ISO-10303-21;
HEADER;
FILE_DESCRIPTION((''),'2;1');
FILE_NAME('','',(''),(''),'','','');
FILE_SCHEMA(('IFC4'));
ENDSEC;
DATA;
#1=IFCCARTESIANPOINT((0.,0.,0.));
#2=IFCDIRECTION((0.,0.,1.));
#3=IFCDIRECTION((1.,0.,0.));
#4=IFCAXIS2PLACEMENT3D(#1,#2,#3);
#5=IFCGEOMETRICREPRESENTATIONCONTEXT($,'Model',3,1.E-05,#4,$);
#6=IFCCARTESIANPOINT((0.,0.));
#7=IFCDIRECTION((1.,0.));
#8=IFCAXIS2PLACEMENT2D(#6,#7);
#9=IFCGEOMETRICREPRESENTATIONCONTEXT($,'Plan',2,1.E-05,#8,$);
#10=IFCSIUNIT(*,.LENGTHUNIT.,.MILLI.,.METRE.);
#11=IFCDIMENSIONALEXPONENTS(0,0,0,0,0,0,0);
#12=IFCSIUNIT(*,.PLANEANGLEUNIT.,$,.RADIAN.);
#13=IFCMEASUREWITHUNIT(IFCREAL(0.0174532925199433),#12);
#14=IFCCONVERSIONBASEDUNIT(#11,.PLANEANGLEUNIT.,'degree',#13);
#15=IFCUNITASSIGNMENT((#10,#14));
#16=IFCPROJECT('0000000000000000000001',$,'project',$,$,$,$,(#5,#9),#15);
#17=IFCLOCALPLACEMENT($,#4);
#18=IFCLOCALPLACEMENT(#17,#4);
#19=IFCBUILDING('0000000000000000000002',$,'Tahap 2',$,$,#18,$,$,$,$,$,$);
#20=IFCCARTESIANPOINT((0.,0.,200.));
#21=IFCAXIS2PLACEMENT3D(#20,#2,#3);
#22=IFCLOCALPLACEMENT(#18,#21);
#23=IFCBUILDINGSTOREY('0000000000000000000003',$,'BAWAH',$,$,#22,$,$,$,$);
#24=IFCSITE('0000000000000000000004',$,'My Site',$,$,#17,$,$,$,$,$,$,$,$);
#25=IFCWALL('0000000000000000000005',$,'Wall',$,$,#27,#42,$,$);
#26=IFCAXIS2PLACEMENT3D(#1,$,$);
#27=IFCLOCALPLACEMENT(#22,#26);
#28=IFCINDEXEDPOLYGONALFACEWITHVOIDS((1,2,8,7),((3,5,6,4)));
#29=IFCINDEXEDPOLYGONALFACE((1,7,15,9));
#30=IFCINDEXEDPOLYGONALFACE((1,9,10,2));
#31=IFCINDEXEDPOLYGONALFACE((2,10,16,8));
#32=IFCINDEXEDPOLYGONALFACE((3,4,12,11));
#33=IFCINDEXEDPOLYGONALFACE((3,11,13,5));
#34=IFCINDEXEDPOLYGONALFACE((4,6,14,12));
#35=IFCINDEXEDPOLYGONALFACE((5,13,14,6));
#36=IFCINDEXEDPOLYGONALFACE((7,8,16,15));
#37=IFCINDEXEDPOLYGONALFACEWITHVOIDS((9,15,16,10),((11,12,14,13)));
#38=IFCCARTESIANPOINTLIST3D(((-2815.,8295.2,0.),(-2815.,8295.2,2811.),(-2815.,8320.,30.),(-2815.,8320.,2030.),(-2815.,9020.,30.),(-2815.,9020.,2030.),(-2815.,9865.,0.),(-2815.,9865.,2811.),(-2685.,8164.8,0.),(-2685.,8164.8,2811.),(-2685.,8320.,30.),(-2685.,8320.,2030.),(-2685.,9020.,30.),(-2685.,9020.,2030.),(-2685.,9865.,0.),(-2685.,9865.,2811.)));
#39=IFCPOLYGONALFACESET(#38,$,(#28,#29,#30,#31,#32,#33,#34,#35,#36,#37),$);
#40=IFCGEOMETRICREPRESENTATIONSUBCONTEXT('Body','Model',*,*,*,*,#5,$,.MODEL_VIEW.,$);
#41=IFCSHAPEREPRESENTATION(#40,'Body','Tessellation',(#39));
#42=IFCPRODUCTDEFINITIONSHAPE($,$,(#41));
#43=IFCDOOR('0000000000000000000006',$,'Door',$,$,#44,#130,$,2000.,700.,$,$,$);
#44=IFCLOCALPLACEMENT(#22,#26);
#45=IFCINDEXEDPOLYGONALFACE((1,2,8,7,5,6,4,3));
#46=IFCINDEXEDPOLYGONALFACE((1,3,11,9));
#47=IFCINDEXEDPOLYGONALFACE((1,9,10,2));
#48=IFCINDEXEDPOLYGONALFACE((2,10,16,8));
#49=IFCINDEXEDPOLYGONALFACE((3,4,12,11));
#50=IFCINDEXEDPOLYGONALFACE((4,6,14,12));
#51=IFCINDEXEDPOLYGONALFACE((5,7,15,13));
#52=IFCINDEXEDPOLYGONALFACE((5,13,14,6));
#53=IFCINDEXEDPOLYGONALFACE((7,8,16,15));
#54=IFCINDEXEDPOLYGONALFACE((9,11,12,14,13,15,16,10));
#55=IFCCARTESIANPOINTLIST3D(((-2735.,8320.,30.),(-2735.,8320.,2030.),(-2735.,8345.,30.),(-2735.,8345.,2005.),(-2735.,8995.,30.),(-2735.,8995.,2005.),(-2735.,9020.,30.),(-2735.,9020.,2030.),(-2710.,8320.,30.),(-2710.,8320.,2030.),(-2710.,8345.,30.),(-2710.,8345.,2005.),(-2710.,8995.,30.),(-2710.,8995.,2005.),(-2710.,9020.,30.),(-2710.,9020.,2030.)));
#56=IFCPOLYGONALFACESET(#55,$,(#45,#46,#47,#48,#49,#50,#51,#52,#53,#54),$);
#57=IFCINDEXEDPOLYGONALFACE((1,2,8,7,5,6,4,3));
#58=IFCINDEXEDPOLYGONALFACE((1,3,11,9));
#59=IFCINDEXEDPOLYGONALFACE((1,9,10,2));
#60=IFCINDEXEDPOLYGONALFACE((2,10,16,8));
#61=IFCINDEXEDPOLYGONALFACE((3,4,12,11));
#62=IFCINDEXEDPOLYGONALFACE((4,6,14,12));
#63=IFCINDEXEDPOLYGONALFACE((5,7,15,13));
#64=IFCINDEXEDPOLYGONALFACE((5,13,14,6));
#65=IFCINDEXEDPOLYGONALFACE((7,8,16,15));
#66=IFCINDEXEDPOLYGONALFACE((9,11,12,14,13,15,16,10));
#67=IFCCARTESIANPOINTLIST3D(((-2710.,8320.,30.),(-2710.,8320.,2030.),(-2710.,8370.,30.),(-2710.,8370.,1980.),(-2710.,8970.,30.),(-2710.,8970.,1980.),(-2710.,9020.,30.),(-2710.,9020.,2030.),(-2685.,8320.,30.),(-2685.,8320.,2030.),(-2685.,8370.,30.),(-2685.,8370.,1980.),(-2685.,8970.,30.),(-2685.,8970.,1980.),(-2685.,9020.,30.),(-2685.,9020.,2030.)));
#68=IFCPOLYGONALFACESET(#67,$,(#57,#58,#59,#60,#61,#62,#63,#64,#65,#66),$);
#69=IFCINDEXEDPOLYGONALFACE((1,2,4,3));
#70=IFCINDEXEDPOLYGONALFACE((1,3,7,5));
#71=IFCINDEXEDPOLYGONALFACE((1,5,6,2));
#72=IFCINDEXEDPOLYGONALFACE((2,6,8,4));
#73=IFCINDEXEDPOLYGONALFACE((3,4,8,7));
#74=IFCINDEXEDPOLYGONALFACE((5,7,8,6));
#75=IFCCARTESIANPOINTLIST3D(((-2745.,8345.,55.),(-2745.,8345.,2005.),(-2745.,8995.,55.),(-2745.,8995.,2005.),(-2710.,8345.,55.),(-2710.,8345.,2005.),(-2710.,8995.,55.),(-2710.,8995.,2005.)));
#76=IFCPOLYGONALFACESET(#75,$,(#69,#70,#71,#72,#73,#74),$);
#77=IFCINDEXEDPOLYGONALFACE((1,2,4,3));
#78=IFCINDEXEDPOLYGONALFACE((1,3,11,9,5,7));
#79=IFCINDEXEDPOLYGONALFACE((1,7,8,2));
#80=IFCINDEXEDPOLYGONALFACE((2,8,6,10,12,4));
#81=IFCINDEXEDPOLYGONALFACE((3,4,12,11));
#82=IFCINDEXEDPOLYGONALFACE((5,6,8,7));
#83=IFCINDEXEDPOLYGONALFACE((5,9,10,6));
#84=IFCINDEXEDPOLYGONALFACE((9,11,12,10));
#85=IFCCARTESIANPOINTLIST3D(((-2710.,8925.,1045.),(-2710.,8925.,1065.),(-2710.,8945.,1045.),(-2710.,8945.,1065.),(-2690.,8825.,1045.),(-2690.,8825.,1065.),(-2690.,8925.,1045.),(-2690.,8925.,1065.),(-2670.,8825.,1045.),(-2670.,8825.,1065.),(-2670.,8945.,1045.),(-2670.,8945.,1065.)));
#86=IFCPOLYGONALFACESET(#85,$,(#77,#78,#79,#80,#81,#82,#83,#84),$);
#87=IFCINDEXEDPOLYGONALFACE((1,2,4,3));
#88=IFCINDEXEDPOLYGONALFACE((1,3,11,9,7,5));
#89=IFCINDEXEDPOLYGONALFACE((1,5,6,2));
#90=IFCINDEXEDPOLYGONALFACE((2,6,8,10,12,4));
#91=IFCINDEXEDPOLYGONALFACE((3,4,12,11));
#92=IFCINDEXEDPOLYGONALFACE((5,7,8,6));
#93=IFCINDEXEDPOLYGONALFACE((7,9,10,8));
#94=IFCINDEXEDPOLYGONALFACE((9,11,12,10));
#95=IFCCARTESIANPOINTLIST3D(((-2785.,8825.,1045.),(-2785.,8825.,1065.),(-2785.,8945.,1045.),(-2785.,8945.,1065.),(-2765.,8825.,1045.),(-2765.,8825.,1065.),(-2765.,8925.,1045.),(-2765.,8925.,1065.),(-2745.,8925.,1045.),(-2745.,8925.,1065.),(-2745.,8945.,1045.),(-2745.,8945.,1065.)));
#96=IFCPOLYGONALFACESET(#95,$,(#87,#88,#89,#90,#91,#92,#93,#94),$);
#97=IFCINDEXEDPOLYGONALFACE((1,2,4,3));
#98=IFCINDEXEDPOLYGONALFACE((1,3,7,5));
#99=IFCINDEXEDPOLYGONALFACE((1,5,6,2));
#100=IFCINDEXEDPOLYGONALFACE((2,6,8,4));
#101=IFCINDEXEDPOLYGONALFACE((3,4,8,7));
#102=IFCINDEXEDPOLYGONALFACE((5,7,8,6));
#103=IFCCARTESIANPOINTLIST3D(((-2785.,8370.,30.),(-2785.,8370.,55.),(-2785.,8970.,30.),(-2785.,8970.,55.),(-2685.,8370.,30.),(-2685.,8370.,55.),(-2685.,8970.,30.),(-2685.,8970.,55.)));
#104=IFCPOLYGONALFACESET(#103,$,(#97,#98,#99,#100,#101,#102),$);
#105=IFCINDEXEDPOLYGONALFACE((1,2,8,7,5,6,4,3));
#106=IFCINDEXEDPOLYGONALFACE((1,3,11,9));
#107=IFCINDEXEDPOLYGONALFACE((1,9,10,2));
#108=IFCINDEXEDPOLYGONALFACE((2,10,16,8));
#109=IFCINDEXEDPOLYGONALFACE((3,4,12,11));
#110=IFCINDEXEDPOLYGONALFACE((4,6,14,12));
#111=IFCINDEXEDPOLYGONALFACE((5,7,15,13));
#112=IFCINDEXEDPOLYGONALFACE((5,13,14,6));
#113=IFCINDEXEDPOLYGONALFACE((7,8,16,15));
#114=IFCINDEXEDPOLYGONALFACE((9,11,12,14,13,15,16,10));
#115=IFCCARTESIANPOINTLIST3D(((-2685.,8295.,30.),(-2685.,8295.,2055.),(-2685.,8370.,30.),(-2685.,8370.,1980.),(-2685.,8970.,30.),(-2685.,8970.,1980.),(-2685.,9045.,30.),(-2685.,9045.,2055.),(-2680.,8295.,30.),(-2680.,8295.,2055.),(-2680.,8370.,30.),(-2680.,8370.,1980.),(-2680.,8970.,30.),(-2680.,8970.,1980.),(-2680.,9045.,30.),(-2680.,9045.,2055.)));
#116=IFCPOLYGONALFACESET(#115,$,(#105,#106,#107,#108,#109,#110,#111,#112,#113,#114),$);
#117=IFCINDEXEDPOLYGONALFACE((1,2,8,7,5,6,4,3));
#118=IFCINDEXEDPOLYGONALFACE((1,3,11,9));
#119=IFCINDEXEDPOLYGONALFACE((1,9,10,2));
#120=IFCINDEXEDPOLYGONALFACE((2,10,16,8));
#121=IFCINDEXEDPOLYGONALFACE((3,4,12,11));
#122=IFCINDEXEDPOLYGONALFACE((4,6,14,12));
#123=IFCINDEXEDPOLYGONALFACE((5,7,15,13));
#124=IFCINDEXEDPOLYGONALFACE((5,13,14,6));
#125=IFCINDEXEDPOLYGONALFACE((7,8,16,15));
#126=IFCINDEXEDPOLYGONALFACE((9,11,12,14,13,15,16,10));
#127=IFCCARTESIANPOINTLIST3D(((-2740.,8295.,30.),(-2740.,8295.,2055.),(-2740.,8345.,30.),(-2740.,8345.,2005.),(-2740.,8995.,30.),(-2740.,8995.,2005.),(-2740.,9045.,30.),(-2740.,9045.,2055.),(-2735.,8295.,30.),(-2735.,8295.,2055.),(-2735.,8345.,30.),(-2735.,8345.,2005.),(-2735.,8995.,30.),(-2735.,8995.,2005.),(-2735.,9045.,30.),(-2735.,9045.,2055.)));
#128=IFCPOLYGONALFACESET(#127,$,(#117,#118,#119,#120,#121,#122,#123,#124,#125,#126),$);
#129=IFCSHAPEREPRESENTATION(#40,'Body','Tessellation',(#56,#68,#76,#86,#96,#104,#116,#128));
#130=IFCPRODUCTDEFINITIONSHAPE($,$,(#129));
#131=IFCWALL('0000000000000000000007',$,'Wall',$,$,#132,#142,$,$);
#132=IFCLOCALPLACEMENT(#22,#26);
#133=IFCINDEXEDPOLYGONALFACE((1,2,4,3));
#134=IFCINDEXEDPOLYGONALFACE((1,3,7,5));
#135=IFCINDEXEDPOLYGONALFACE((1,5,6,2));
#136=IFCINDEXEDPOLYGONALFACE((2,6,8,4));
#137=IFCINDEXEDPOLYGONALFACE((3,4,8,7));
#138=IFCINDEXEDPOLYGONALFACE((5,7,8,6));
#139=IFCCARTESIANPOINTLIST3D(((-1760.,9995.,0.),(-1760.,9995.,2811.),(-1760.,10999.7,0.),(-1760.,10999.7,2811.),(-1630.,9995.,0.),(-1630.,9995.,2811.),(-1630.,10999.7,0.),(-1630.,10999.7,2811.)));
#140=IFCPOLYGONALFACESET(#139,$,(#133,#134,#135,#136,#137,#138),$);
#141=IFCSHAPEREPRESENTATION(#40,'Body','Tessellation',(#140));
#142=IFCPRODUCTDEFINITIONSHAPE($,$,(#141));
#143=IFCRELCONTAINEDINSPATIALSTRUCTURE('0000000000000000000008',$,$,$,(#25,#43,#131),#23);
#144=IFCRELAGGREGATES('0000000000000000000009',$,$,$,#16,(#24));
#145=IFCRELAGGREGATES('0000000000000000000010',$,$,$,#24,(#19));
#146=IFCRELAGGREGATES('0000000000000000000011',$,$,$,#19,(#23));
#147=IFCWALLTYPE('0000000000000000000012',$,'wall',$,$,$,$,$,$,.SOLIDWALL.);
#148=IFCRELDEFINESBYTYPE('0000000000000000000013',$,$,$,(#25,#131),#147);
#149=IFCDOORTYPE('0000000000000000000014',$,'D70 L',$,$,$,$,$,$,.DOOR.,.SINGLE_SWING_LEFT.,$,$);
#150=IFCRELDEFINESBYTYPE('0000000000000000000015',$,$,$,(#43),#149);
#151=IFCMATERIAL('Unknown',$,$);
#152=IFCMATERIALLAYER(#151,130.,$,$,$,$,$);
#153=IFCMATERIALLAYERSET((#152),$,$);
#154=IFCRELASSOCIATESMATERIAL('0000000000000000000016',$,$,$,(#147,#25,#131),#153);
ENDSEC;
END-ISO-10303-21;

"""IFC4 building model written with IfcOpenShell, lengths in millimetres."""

from ifc_helpers import new_model, entity, si_unit, converted_unit, frame, origin_with_axes, origin_2d_with_axis, place, context, subcontext, project, spatial, line, indexed_curve, outline, extrude, shape, source, transform, mapped, material, layer, layer_set, layer_usage, type_object, type_shapes, element, fill, save


model = new_model("IFC4")

# Units and contexts
model_context = context("Model", 3, precision=1e-05, world=origin_with_axes())
plan_context = context("Plan", 2, precision=1e-05, world=origin_2d_with_axis())
body_context_1 = subcontext(model_context, "Body", "Model", "MODEL_VIEW")
body_context_2 = subcontext(plan_context, "Body", "Plan", "PLAN_VIEW")
ifc_project = project(units=[si_unit("LENGTHUNIT", "METRE", prefix="MILLI"), converted_unit("PLANEANGLEUNIT", "degree", entity("IfcReal", 0.0174532925199433), si_unit("PLANEANGLEUNIT", "RADIAN"), dimensions=[0, 0, 0, 0, 0, 0, 0])], contexts=[model_context, plan_context])

# Site, building, storey
site_placement = place(None, origin_with_axes())
site = spatial("IfcSite", under=ifc_project, at=site_placement, Name="My Site")
building_placement = place(site_placement, origin_with_axes())
building = spatial("IfcBuilding", under=site, at=building_placement, Name="Tahap 2")
storey_placement = place(building_placement, frame((0.0, 0.0, 200.0), z_axis=(0.0, 0.0, 1.0), x_axis=(1.0, 0.0, 0.0)))
storey = spatial("IfcBuildingStorey", under=building, at=storey_placement, Name="BAWAH")

# Wall, opening, door
ifc_material_1 = material(Name="Unknown")
ifc_layer_1 = layer(ifc_material_1, 130.0)
ifc_layer_set_1 = layer_set([ifc_layer_1])
ifc_layer_usage_1 = layer_usage(ifc_layer_set_1, "AXIS2", "POSITIVE", 0.0)
wall_type = type_object("IfcWallType", Name="wall", PredefinedType="SOLIDWALL", material=ifc_layer_set_1)
wall_1_placement = place(storey_placement, frame((-2685.0, 8164.8, 0.0), z_axis=(0.0, 0.0, 1.0), x_axis=(0.0, 1.0, 0.0)))
wall_1 = element("IfcWall", 1, at=wall_1_placement, inside=storey, type_object=wall_type, material=ifc_layer_usage_1, Name="Wall", context=body_context_1, shape_type="SweptSolid", body=[
    extrude(outline(indexed_curve([(0.0, 0.0), (130.3, 130.0), (1700.2, 130.0), (1700.2, 0.0)], segments=[line(1, 2, 3, 4, 1)])), origin_with_axes(), (0.0, 0.0, 1.0), 2811.0),
])
shared_shape_1 = source(origin_with_axes(), body_context_1, "Body", "SweptSolid", [
    extrude(outline(indexed_curve([(0.0, 0.0), (700.0, 0.0), (700.0, 2000.0), (0.0, 2000.0)], segments=[line(1, 2, 3, 4, 1)])), frame((0.0, -600.0, 0.0), z_axis=(0.0, -1.0, 0.0), x_axis=(1.0, 0.0, 0.0)), (0.0, 0.0, -1.0), 1200.0),
])
opening_placement = place(wall_1_placement, frame((155.2, 0.0, 30.0), z_axis=(0.0, 0.0, 1.0), x_axis=(1.0, 0.0, 0.0)))
opening = element("IfcOpeningElement", 2, at=opening_placement, cuts=wall_1, PredefinedType="OPENING", context=body_context_1, shape_type="MappedRepresentation", body=[
    mapped(shared_shape_1, transform((0.0, 0.0, 0.0), x_axis=(1.0, 0.0, 0.0), y_axis=(0.0, 1.0, 0.0), z_axis=(0.0, 0.0, 1.0), scale=1.0)),
])
door_type = type_object("IfcDoorType", Name="D70 L", OperationType="SINGLE_SWING_LEFT", PredefinedType="DOOR")
shared_shape_2 = source(origin_with_axes(), body_context_1, "Body", "SweptSolid", [
    extrude(outline(indexed_curve([(0.0, 0.0), (0.0, 2000.0), (700.0, 2000.0), (700.0, 0.0), (675.0, 0.0), (675.0, 1975.0), (25.0, 1975.0), (25.0, 0.0)], segments=[line(1, 2, 3, 4, 5, 6, 7, 8, 1)])), frame((0.0, 25.0, 0.0), z_axis=(0.0, -1.0, 0.0), x_axis=(1.0, 0.0, 0.0)), (0.0, 0.0, -1.0), 25.0),
    extrude(outline(indexed_curve([(0.0, 0.0), (0.0, 2000.0), (700.0, 2000.0), (700.0, 0.0), (650.0, 0.0), (650.0, 1950.0), (50.0, 1950.0), (50.0, 0.0)], segments=[line(1, 2, 3, 4, 5, 6, 7, 8, 1)])), frame((0.0, 0.0, 0.0), z_axis=(0.0, -1.0, 0.0), x_axis=(1.0, 0.0, 0.0)), (0.0, 0.0, -1.0), 25.0),
    extrude(outline(indexed_curve([(0.0, 0.0), (650.0, 0.0), (650.0, 35.0), (0.0, 35.0)], segments=[line(1, 2, 3, 4, 1)])), frame((25.0, 25.0, 25.0), z_axis=(0.0, 0.0, 1.0), x_axis=(1.0, 0.0, 0.0)), (0.0, 0.0, 1.0), 1950.0),
    extrude(outline(indexed_curve([(0.0, 0.0), (0.0, -40.0), (-120.0, -40.0), (-120.0, -20.0), (-20.0, -20.0), (-20.0, 0.0)], segments=[line(1, 2, 3, 4, 5, 6, 1)])), frame((625.0, 25.0, 1015.0), z_axis=(0.0, 0.0, 1.0), x_axis=(1.0, 0.0, 0.0)), (0.0, 0.0, 1.0), 20.0),
    extrude(outline(indexed_curve([(0.0, 0.0), (0.0, 40.0), (-120.0, 40.0), (-120.0, 20.0), (-20.0, 20.0), (-20.0, 0.0)], segments=[line(1, 2, 3, 4, 5, 6, 1)])), frame((625.0, 60.0, 1015.0), z_axis=(0.0, 0.0, 1.0), x_axis=(1.0, 0.0, 0.0)), (0.0, 0.0, 1.0), 20.0),
    extrude(outline(indexed_curve([(0.0, 0.0), (600.0, 0.0), (600.0, 100.0), (0.0, 100.0)], segments=[line(1, 2, 3, 4, 1)])), frame((50.0, 0.0, 0.0), z_axis=(0.0, 0.0, 1.0), x_axis=(1.0, 0.0, 0.0)), (0.0, 0.0, 1.0), 25.0),
    extrude(outline(indexed_curve([(0.0, 0.0), (0.0, 2025.0), (750.0, 2025.0), (750.0, 0.0), (675.0, 0.0), (675.0, 1950.0), (75.0, 1950.0), (75.0, 0.0)], segments=[line(1, 2, 3, 4, 5, 6, 7, 8, 1)])), frame((-25.0, -5.0, 0.0), z_axis=(0.0, -1.0, 0.0), x_axis=(1.0, 0.0, 0.0)), (0.0, 0.0, -1.0), 5.0),
    extrude(outline(indexed_curve([(0.0, 0.0), (0.0, 2025.0), (750.0, 2025.0), (750.0, 0.0), (700.0, 0.0), (700.0, 1975.0), (50.0, 1975.0), (50.0, 0.0)], segments=[line(1, 2, 3, 4, 5, 6, 7, 8, 1)])), frame((-25.0, 50.0, 0.0), z_axis=(0.0, -1.0, 0.0), x_axis=(1.0, 0.0, 0.0)), (0.0, 0.0, -1.0), 5.0),
])
shared_shape_3 = source(origin_with_axes(), body_context_2, "Body", "Curve2D", [
    entity("IfcIndexedPolyCurve", entity("IfcCartesianPointList2D", [[0.0, 0.0], [0.0, 50.0], [25.0, 50.0], [25.0, 25.0], [50.0, 25.0], [50.0, 0.0]]), [entity("IfcLineIndex", [1, 2, 3, 4, 5, 6, 1])]),
    entity("IfcIndexedPolyCurve", entity("IfcCartesianPointList2D", [[700.0, 0.0], [700.0, 50.0], [675.0, 50.0], [675.0, 25.0], [650.0, 25.0], [650.0, 0.0]]), [entity("IfcLineIndex", [1, 2, 3, 4, 5, 6, 1])]),
    entity("IfcTrimmedCurve", entity("IfcEllipse", entity("IfcAxis2Placement2D", entity("IfcCartesianPoint", [60.0, 50.0]), entity("IfcDirection", [1.0, 0.0])), 615.0, 650.0), [entity("IfcCartesianPoint", [675.0, 50.0])], [entity("IfcCartesianPoint", [60.0, 700.0])], True, "CARTESIAN"),
    entity("IfcIndexedPolyCurve", entity("IfcCartesianPointList2D", [[25.0, 50.0], [60.0, 50.0], [60.0, 700.0], [25.0, 700.0]]), [entity("IfcLineIndex", [1, 2, 3, 4, 1])]),
])
type_shapes(door_type, [shared_shape_2, shared_shape_3])
door_placement = place(opening_placement, frame((0.0, 0.0, 0.0), z_axis=(0.0, 0.0, 1.0), x_axis=(1.0, 0.0, 0.0)))
door = element("IfcDoor", 3, at=door_placement, inside=storey, type_object=door_type, Name="Door", OverallHeight=2000.0, OverallWidth=700.0, shapes=[
    shape(body_context_1, "Body", "MappedRepresentation", [mapped(shared_shape_2, transform((0.0, 0.0, 0.0), x_axis=(1.0, 0.0, 0.0), y_axis=(0.0, 1.0, 0.0), z_axis=(0.0, 0.0, 1.0), scale=1.0))]),
    shape(body_context_2, "Body", "MappedRepresentation", [mapped(shared_shape_3, transform((0.0, 0.0, 0.0), x_axis=(1.0, 0.0, 0.0), y_axis=(0.0, 1.0, 0.0), z_axis=(0.0, 0.0, 1.0), scale=1.0))]),
])
fill(opening, door)

# Wall
ifc_layer_usage_2 = layer_usage(ifc_layer_set_1, "AXIS2", "NEGATIVE", 0.0)
wall_2_placement = place(storey_placement, frame((-1760.0, 9995.0, 0.0), z_axis=(0.0, 0.0, 1.0), x_axis=(0.0, 1.0, 0.0)))
element("IfcWall", 4, at=wall_2_placement, inside=storey, type_object=wall_type, material=ifc_layer_usage_2, Name="Wall", context=body_context_1, shape_type="SweptSolid", body=[
    extrude(outline(indexed_curve([(0.0, -130.0), (0.0, 0.0), (1004.7, 0.0), (1004.7, -130.0)], segments=[line(1, 2, 3, 4, 1)])), origin_with_axes(), (0.0, 0.0, 1.0), 2811.0),
])

save(model, "model.ifc")
